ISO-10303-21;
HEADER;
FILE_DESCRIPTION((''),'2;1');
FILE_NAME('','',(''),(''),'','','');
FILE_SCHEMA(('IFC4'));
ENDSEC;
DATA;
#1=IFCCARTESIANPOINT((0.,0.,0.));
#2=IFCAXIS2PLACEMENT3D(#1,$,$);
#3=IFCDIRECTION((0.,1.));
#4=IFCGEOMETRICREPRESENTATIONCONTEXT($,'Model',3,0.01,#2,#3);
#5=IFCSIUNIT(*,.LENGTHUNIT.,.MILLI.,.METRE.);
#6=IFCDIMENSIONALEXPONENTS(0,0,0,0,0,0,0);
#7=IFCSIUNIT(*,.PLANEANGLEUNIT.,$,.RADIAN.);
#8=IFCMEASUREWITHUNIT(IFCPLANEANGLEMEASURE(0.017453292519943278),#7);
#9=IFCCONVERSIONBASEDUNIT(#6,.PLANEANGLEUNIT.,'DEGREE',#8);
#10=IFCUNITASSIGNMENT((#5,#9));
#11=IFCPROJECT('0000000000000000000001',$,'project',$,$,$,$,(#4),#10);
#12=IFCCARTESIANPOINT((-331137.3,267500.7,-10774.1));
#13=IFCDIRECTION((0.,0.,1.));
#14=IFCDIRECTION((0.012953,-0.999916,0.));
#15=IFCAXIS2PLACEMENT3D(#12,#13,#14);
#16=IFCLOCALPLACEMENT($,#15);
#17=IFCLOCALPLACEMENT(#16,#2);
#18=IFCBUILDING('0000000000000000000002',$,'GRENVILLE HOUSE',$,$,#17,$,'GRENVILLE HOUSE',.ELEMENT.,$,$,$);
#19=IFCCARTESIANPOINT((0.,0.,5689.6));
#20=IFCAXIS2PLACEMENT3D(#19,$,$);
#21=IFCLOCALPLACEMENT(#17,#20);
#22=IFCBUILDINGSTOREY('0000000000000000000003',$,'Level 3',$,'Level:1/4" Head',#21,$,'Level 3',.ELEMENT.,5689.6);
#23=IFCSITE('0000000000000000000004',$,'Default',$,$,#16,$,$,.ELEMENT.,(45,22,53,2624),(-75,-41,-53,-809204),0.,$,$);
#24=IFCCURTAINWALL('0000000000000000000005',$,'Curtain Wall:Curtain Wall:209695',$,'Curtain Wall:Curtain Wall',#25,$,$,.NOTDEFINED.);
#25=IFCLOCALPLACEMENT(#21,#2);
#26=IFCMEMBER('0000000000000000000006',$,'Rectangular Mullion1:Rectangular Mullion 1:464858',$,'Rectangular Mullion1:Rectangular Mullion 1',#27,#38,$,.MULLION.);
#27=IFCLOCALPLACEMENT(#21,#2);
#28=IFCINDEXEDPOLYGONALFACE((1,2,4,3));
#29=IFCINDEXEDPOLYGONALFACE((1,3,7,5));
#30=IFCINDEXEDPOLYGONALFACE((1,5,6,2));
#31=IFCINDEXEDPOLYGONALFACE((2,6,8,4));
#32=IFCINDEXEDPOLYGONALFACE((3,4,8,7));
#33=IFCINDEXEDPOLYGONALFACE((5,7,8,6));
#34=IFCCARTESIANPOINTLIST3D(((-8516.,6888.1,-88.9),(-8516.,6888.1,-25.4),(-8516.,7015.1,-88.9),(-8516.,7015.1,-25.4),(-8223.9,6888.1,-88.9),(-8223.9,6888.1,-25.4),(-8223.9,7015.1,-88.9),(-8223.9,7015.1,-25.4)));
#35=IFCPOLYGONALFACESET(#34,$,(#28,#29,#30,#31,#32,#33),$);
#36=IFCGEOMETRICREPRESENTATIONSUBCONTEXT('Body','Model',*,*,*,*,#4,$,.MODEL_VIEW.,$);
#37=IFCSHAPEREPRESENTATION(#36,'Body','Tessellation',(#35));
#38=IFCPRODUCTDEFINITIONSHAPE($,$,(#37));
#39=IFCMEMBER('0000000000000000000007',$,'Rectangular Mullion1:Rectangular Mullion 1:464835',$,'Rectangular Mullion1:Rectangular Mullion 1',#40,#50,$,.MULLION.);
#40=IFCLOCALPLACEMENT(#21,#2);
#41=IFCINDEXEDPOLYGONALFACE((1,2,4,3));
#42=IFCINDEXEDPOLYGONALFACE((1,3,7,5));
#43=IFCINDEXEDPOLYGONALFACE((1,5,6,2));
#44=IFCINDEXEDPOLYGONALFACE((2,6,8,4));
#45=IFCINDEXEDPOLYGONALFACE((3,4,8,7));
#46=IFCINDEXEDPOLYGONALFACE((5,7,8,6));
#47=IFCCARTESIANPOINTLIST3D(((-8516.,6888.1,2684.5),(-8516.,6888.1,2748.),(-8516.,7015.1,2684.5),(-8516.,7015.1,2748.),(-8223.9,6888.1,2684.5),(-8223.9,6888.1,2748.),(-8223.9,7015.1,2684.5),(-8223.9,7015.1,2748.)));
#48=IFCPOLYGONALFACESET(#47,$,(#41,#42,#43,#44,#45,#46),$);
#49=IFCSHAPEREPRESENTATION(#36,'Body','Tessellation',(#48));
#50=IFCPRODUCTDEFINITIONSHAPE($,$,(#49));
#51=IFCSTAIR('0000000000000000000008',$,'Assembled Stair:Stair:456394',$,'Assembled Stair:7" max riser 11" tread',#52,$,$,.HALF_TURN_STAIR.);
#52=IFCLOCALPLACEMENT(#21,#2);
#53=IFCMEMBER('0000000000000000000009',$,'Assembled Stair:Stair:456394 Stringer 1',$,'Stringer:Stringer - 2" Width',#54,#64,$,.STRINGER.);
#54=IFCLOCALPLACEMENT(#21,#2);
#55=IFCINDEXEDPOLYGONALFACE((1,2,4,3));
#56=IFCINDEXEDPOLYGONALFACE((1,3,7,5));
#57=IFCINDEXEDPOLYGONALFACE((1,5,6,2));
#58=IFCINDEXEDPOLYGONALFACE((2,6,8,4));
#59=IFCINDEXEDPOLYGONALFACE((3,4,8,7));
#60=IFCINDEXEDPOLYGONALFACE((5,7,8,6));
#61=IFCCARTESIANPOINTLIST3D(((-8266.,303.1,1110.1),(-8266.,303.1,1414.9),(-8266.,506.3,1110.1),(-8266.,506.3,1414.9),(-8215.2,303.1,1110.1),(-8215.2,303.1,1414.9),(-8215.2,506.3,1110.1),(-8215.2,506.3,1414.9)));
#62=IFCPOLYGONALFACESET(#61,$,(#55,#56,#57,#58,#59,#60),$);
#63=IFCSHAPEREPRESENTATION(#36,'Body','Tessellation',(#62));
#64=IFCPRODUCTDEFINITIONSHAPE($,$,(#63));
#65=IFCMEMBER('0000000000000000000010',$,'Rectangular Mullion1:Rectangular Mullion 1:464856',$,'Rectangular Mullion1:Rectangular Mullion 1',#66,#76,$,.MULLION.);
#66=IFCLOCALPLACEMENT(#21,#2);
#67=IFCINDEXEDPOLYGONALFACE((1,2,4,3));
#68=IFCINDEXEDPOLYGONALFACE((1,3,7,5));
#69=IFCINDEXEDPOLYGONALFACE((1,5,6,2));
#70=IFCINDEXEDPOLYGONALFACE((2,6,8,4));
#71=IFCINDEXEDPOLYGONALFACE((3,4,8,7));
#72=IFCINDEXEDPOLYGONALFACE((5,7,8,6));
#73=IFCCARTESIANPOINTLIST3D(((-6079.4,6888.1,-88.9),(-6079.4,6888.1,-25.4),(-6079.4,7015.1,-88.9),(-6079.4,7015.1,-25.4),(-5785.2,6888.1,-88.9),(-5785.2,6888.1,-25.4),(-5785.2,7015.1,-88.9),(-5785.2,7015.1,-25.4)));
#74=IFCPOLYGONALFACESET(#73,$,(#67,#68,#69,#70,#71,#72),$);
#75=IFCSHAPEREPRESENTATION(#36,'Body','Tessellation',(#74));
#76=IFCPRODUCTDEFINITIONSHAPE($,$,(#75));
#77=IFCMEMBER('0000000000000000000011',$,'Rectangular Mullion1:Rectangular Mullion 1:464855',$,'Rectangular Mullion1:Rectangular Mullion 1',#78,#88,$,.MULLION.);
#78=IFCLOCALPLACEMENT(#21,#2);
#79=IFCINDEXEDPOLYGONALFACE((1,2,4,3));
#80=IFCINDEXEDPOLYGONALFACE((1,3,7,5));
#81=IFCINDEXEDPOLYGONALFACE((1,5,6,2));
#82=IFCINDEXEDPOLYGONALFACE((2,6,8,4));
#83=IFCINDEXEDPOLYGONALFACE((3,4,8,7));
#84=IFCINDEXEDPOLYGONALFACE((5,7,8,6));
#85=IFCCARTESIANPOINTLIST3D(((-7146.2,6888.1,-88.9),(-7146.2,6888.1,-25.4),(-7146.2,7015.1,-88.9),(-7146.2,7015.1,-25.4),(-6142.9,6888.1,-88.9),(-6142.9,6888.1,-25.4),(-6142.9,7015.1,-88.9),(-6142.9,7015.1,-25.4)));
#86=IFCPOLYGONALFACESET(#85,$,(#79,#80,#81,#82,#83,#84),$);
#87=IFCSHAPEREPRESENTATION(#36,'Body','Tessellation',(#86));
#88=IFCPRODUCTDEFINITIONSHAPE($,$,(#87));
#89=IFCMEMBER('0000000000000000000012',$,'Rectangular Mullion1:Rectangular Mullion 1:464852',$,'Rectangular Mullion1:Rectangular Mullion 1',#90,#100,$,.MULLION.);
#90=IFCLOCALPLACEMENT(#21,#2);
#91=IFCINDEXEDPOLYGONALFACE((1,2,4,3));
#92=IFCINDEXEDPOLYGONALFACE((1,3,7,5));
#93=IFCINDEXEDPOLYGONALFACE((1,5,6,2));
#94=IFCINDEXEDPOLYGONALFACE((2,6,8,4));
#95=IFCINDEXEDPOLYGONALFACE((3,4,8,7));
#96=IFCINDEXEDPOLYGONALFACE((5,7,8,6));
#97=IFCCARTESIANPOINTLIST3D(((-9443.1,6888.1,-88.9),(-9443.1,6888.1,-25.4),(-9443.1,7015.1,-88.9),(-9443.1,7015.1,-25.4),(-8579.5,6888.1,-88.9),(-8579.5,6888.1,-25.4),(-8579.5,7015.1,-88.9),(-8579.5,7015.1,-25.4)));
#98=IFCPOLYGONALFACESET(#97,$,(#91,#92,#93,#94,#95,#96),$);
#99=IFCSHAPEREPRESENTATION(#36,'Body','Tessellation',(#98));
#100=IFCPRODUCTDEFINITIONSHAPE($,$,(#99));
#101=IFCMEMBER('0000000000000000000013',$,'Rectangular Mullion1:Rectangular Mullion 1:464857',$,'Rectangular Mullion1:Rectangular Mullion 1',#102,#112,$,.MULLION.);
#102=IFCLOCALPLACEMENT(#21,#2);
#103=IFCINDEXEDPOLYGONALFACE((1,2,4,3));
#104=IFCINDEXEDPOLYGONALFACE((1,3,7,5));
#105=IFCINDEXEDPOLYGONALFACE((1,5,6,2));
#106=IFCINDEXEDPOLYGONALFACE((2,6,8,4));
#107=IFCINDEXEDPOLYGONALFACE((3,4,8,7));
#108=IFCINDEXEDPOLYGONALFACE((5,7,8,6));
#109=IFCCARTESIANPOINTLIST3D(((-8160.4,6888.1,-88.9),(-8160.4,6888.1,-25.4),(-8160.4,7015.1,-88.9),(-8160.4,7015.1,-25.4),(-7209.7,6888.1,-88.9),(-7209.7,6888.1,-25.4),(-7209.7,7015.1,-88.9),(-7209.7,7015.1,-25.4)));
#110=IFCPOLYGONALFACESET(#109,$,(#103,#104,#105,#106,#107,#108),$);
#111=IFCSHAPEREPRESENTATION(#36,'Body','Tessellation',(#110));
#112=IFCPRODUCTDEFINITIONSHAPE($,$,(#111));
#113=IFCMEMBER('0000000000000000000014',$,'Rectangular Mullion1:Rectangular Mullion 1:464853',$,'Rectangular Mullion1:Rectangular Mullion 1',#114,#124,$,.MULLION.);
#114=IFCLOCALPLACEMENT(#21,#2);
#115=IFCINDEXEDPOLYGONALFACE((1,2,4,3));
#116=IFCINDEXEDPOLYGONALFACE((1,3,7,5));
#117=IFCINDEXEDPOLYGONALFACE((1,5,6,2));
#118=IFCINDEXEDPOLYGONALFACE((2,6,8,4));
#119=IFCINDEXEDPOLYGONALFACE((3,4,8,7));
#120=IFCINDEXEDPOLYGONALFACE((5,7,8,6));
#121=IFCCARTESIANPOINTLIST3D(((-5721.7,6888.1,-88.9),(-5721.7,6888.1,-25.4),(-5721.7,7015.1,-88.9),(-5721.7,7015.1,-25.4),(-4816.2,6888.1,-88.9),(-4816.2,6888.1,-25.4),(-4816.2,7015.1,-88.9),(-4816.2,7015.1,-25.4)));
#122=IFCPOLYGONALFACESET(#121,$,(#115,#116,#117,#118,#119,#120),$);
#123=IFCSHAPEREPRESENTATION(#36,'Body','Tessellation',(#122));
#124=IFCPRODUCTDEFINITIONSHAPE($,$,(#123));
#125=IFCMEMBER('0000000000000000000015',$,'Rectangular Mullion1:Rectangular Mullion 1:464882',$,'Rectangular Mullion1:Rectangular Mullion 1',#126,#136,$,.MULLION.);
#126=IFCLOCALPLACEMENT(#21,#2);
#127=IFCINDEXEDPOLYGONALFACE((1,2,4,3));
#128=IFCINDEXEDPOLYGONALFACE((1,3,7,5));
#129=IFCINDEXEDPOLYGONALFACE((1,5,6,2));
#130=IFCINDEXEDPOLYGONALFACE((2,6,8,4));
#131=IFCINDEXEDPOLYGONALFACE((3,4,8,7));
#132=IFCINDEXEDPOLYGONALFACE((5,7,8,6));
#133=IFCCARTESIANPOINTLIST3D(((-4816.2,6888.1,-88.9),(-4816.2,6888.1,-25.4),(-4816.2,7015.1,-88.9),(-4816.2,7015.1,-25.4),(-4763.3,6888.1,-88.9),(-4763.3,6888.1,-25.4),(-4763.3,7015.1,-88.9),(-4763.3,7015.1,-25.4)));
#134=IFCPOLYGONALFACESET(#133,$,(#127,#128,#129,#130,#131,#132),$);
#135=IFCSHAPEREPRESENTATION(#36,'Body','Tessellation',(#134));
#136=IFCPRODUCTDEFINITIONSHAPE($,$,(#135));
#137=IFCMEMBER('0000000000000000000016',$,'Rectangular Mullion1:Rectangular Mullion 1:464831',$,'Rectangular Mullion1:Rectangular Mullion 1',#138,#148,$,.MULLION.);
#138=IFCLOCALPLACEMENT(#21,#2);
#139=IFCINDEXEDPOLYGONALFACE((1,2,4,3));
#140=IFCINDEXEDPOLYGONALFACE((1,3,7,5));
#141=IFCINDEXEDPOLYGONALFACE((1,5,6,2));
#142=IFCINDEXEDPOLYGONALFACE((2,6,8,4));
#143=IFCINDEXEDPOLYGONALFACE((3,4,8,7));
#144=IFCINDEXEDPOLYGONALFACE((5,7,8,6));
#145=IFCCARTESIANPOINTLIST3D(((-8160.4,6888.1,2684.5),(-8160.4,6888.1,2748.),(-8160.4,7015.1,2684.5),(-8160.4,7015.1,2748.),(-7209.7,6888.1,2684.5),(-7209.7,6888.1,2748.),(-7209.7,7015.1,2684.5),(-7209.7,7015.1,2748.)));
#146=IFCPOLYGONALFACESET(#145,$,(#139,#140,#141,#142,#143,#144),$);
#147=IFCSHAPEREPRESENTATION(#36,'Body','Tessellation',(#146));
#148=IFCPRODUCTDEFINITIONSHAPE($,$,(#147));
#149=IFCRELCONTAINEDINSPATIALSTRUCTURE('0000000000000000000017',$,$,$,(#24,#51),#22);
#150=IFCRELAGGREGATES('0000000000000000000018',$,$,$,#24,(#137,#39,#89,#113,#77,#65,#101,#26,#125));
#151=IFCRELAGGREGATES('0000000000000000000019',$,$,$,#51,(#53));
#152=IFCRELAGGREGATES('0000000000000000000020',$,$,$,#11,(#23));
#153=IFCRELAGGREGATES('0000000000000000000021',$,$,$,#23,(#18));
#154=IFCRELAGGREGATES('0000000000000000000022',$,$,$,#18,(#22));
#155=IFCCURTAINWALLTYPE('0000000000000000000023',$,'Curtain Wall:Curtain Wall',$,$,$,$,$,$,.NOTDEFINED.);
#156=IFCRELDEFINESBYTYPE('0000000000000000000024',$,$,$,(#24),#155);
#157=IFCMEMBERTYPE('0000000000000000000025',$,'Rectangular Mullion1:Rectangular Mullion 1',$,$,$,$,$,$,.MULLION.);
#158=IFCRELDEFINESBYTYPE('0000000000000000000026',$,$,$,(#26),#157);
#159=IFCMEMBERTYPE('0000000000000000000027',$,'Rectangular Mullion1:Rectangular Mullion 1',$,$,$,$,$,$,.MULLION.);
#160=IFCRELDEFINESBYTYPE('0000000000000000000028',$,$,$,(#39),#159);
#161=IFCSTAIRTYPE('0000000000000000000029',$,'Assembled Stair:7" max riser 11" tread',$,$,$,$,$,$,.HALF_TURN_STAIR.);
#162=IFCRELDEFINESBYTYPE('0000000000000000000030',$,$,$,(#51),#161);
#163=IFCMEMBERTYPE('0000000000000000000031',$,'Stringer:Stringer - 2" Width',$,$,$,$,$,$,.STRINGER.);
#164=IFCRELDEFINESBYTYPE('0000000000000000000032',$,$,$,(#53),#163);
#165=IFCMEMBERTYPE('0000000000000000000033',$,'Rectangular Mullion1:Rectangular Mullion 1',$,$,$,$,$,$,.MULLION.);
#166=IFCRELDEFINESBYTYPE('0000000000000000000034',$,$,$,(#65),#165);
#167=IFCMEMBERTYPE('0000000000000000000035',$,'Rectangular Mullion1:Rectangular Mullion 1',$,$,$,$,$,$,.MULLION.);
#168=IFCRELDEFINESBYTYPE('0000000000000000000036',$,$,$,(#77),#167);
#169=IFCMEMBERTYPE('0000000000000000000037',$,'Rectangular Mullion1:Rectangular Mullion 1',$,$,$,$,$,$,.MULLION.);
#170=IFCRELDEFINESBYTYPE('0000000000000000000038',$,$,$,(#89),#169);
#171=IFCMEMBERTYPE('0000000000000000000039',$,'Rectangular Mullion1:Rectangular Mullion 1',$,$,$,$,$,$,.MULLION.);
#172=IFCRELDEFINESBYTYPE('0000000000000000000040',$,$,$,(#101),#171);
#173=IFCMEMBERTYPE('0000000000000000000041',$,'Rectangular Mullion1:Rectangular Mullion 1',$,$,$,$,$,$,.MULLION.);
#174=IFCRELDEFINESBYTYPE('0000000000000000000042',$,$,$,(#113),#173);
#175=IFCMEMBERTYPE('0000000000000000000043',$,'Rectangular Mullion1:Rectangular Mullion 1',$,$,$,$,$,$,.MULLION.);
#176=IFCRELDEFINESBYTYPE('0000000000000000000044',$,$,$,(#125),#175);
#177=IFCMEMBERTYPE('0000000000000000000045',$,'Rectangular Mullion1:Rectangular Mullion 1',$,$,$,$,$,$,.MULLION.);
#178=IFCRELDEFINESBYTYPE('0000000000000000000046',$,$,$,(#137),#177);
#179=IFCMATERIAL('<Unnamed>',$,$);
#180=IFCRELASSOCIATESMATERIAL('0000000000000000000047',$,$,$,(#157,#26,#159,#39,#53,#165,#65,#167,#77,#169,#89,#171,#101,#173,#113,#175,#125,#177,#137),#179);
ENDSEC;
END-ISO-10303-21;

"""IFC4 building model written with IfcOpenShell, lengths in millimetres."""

from ifc_helpers import new_model, entity, si_unit, converted_unit, direction, frame, origin, place, context, subcontext, project, spatial, indexed_curve, outline, extrude, source, transform, mapped, material, type_object, type_shapes, element, aggregate, save


model = new_model("IFC4")

# Units and contexts
model_context = context("Model", 3, precision=0.01, world=origin(), true_north=direction((0.0, 1.0)))
body_context = subcontext(model_context, "Body", "Model", "MODEL_VIEW")
ifc_project = project(units=[si_unit("LENGTHUNIT", "METRE", prefix="MILLI"), converted_unit("PLANEANGLEUNIT", "DEGREE", entity("IfcPlaneAngleMeasure", 0.017453292519943278), si_unit("PLANEANGLEUNIT", "RADIAN"), dimensions=[0, 0, 0, 0, 0, 0, 0])], contexts=[model_context])

# Site, building, storey
site_placement = place(None, frame((-331137.3, 267500.7, -10774.1), z_axis=(0.0, 0.0, 1.0), x_axis=(0.012953, -0.999916, 0.0)))
site = spatial("IfcSite", under=ifc_project, at=site_placement, Name="Default", CompositionType="ELEMENT", RefLatitude=(45, 22, 53, 2624), RefLongitude=(-75, -41, -53, -809204), RefElevation=0.0)
building_placement = place(site_placement, origin())
building = spatial("IfcBuilding", under=site, at=building_placement, Name="GRENVILLE HOUSE", LongName="GRENVILLE HOUSE", CompositionType="ELEMENT")
storey_placement = place(building_placement, frame((0.0, 0.0, 5689.6)))
storey = spatial("IfcBuildingStorey", under=building, at=storey_placement, Name="Level 3", ObjectType="Level:1/4\" Head", LongName="Level 3", CompositionType="ELEMENT", Elevation=5689.6)

# Curtain wall, members
curtain_wall_type = type_object("IfcCurtainWallType", Name="Curtain Wall:Curtain Wall", PredefinedType="NOTDEFINED")
curtain_wall_placement = place(storey_placement, frame((0.0, 0.0, -5689.6)))
curtain_wall = element("IfcCurtainWall", 1, at=curtain_wall_placement, inside=storey, type_object=curtain_wall_type, Name="Curtain Wall:Curtain Wall:209695", ObjectType="Curtain Wall:Curtain Wall", PredefinedType="NOTDEFINED")
ifc_material_1 = material(Name="<Unnamed>")
member_type_1 = type_object("IfcMemberType", Name="Rectangular Mullion1:Rectangular Mullion 1", PredefinedType="MULLION", material=ifc_material_1)
shared_shape_1 = source(origin(), body_context, "Body", "SweptSolid", [
    extrude(outline(indexed_curve([(-31.8, -63.5), (31.8, -63.5), (31.8, 63.5), (-31.8, 63.5), (-31.8, -63.5)], self_intersect=False)), frame((-31.8, 0.0, -292.1), z_axis=(0.0, 0.0, 1.0), x_axis=(-1.0, 0.0, 0.0)), (0.0, 0.0, 1.0), 292.1),
])
type_shapes(member_type_1, [shared_shape_1])
member_1_placement = place(curtain_wall_placement, frame((-8223.9, 6951.6, 5600.7), z_axis=(1.0, 0.0, 0.0), x_axis=(0.0, 0.0, -1.0)))
member_1 = element("IfcMember", 2, at=member_1_placement, type_object=member_type_1, material=ifc_material_1, Name="Rectangular Mullion1:Rectangular Mullion 1:464858", ObjectType="Rectangular Mullion1:Rectangular Mullion 1", PredefinedType="MULLION", context=body_context, shape_type="MappedRepresentation", body=[
    mapped(shared_shape_1, transform((0.0, 0.0, 0.0), scale=1.0)),
])
member_type_2 = type_object("IfcMemberType", Name="Rectangular Mullion1:Rectangular Mullion 1", PredefinedType="MULLION", material=ifc_material_1)
shared_shape_2 = source(origin(), body_context, "Body", "SweptSolid", [
    extrude(outline(indexed_curve([(-31.8, -63.5), (31.8, -63.5), (31.8, 63.5), (-31.8, 63.5), (-31.8, -63.5)], self_intersect=False)), frame((-31.8, 0.0, -292.1), z_axis=(0.0, 0.0, 1.0), x_axis=(-1.0, 0.0, 0.0)), (0.0, 0.0, 1.0), 292.1),
])
type_shapes(member_type_2, [shared_shape_2])
member_2_placement = place(curtain_wall_placement, frame((-8516.0, 6951.6, 8437.6), z_axis=(-1.0, 0.0, 0.0), x_axis=(0.0, 0.0, 1.0)))
member_2 = element("IfcMember", 3, at=member_2_placement, type_object=member_type_2, material=ifc_material_1, Name="Rectangular Mullion1:Rectangular Mullion 1:464835", ObjectType="Rectangular Mullion1:Rectangular Mullion 1", PredefinedType="MULLION", context=body_context, shape_type="MappedRepresentation", body=[
    mapped(shared_shape_2, transform((0.0, 0.0, 0.0), scale=1.0)),
])

# Stair, member
stair_type = type_object("IfcStairType", Name="Assembled Stair:7\" max riser 11\" tread", PredefinedType="HALF_TURN_STAIR")
stair_placement = place(storey_placement, origin())
stair = element("IfcStair", 4, at=stair_placement, inside=storey, type_object=stair_type, Name="Assembled Stair:Stair:456394", ObjectType="Assembled Stair:7\" max riser 11\" tread", PredefinedType="HALF_TURN_STAIR")
member_type_3 = type_object("IfcMemberType", Name="Stringer:Stringer - 2\" Width", PredefinedType="STRINGER")
member_3_placement = place(stair_placement, frame((-8266.0, 303.1, 1110.1)))
member_3 = element("IfcMember", 5, at=member_3_placement, type_object=member_type_3, material=ifc_material_1, Name="Assembled Stair:Stair:456394 Stringer 1", ObjectType="Stringer:Stringer - 2\" Width", PredefinedType="STRINGER", context=body_context, shape_type="SweptSolid", body=[
    extrude(outline(indexed_curve([(-101.6, -25.4), (101.6, -25.4), (101.6, 25.4), (-101.6, 25.4), (-101.6, -25.4)], self_intersect=False)), frame((25.4, 101.6, 0.0), z_axis=(0.0, 0.0, 1.0), x_axis=(0.0, 1.0, 0.0)), (0.0, 0.0, 1.0), 304.8),
])

# Members
member_type_4 = type_object("IfcMemberType", Name="Rectangular Mullion1:Rectangular Mullion 1", PredefinedType="MULLION", material=ifc_material_1)
shared_shape_3 = source(origin(), body_context, "Body", "SweptSolid", [
    extrude(outline(indexed_curve([(-31.8, -63.5), (31.8, -63.5), (31.8, 63.5), (-31.8, 63.5), (-31.8, -63.5)], self_intersect=False)), frame((-31.8, 0.0, -294.2), z_axis=(0.0, 0.0, 1.0), x_axis=(-1.0, 0.0, 0.0)), (0.0, 0.0, 1.0), 294.2),
])
type_shapes(member_type_4, [shared_shape_3])
member_4_placement = place(curtain_wall_placement, frame((-5785.2, 6951.6, 5600.7), z_axis=(1.0, 0.0, 0.0), x_axis=(0.0, 0.0, -1.0)))
member_4 = element("IfcMember", 6, at=member_4_placement, type_object=member_type_4, material=ifc_material_1, Name="Rectangular Mullion1:Rectangular Mullion 1:464856", ObjectType="Rectangular Mullion1:Rectangular Mullion 1", PredefinedType="MULLION", context=body_context, shape_type="MappedRepresentation", body=[
    mapped(shared_shape_3, transform((0.0, 0.0, 0.0), scale=1.0)),
])
member_type_5 = type_object("IfcMemberType", Name="Rectangular Mullion1:Rectangular Mullion 1", PredefinedType="MULLION", material=ifc_material_1)
shared_shape_4 = source(origin(), body_context, "Body", "SweptSolid", [
    extrude(outline(indexed_curve([(-31.8, -63.5), (31.8, -63.5), (31.8, 63.5), (-31.8, 63.5), (-31.8, -63.5)], self_intersect=False)), frame((-31.8, 0.0, -1003.3), z_axis=(0.0, 0.0, 1.0), x_axis=(-1.0, 0.0, 0.0)), (0.0, 0.0, 1.0), 1003.3),
])
type_shapes(member_type_5, [shared_shape_4])
member_5_placement = place(curtain_wall_placement, frame((-6142.9, 6951.6, 5600.7), z_axis=(1.0, 0.0, 0.0), x_axis=(0.0, 0.0, -1.0)))
member_5 = element("IfcMember", 7, at=member_5_placement, type_object=member_type_5, material=ifc_material_1, Name="Rectangular Mullion1:Rectangular Mullion 1:464855", ObjectType="Rectangular Mullion1:Rectangular Mullion 1", PredefinedType="MULLION", context=body_context, shape_type="MappedRepresentation", body=[
    mapped(shared_shape_4, transform((0.0, 0.0, 0.0), scale=1.0)),
])
member_type_6 = type_object("IfcMemberType", Name="Rectangular Mullion1:Rectangular Mullion 1", PredefinedType="MULLION", material=ifc_material_1)
shared_shape_5 = source(origin(), body_context, "Body", "SweptSolid", [
    extrude(outline(indexed_curve([(-31.8, -63.5), (31.8, -63.5), (31.8, 63.5), (-31.8, 63.5), (-31.8, -63.5)], self_intersect=False)), frame((-31.8, 0.0, -863.6), z_axis=(0.0, 0.0, 1.0), x_axis=(-1.0, 0.0, 0.0)), (0.0, 0.0, 1.0), 863.6),
])
type_shapes(member_type_6, [shared_shape_5])
member_6_placement = place(curtain_wall_placement, frame((-8579.5, 6951.6, 5600.7), z_axis=(1.0, 0.0, 0.0), x_axis=(0.0, 0.0, -1.0)))
member_6 = element("IfcMember", 8, at=member_6_placement, type_object=member_type_6, material=ifc_material_1, Name="Rectangular Mullion1:Rectangular Mullion 1:464852", ObjectType="Rectangular Mullion1:Rectangular Mullion 1", PredefinedType="MULLION", context=body_context, shape_type="MappedRepresentation", body=[
    mapped(shared_shape_5, transform((0.0, 0.0, 0.0), scale=1.0)),
])
member_type_7 = type_object("IfcMemberType", Name="Rectangular Mullion1:Rectangular Mullion 1", PredefinedType="MULLION", material=ifc_material_1)
shared_shape_6 = source(origin(), body_context, "Body", "SweptSolid", [
    extrude(outline(indexed_curve([(-31.8, -63.5), (31.8, -63.5), (31.8, 63.5), (-31.8, 63.5), (-31.8, -63.5)], self_intersect=False)), frame((-31.8, 0.0, -950.7), z_axis=(0.0, 0.0, 1.0), x_axis=(-1.0, 0.0, 0.0)), (0.0, 0.0, 1.0), 950.7),
])
type_shapes(member_type_7, [shared_shape_6])
member_7_placement = place(curtain_wall_placement, frame((-7209.7, 6951.6, 5600.7), z_axis=(1.0, 0.0, 0.0), x_axis=(0.0, 0.0, -1.0)))
member_7 = element("IfcMember", 9, at=member_7_placement, type_object=member_type_7, material=ifc_material_1, Name="Rectangular Mullion1:Rectangular Mullion 1:464857", ObjectType="Rectangular Mullion1:Rectangular Mullion 1", PredefinedType="MULLION", context=body_context, shape_type="MappedRepresentation", body=[
    mapped(shared_shape_6, transform((0.0, 0.0, 0.0), scale=1.0)),
])
member_type_8 = type_object("IfcMemberType", Name="Rectangular Mullion1:Rectangular Mullion 1", PredefinedType="MULLION", material=ifc_material_1)
shared_shape_7 = source(origin(), body_context, "Body", "SweptSolid", [
    extrude(outline(indexed_curve([(-31.8, -63.5), (31.8, -63.5), (31.8, 63.5), (-31.8, 63.5), (-31.8, -63.5)], self_intersect=False)), frame((-31.8, 0.0, -905.5), z_axis=(0.0, 0.0, 1.0), x_axis=(-1.0, 0.0, 0.0)), (0.0, 0.0, 1.0), 905.5),
])
type_shapes(member_type_8, [shared_shape_7])
member_8_placement = place(curtain_wall_placement, frame((-4816.2, 6951.6, 5600.7), z_axis=(1.0, 0.0, 0.0), x_axis=(0.0, 0.0, -1.0)))
member_8 = element("IfcMember", 10, at=member_8_placement, type_object=member_type_8, material=ifc_material_1, Name="Rectangular Mullion1:Rectangular Mullion 1:464853", ObjectType="Rectangular Mullion1:Rectangular Mullion 1", PredefinedType="MULLION", context=body_context, shape_type="MappedRepresentation", body=[
    mapped(shared_shape_7, transform((0.0, 0.0, 0.0), scale=1.0)),
])
member_type_9 = type_object("IfcMemberType", Name="Rectangular Mullion1:Rectangular Mullion 1", PredefinedType="MULLION", material=ifc_material_1)
shared_shape_8 = source(origin(), body_context, "Body", "SweptSolid", [
    extrude(outline(indexed_curve([(-31.8, -63.5), (31.8, -63.5), (31.8, 63.5), (-31.8, 63.5), (-31.8, -63.5)], self_intersect=False)), frame((-31.8, 0.0, -52.9), z_axis=(0.0, 0.0, 1.0), x_axis=(-1.0, 0.0, 0.0)), (0.0, 0.0, 1.0), 52.9),
])
type_shapes(member_type_9, [shared_shape_8])
member_9_placement = place(curtain_wall_placement, frame((-4763.3, 6951.6, 5600.7), z_axis=(1.0, 0.0, 0.0), x_axis=(0.0, 0.0, -1.0)))
member_9 = element("IfcMember", 11, at=member_9_placement, type_object=member_type_9, material=ifc_material_1, Name="Rectangular Mullion1:Rectangular Mullion 1:464882", ObjectType="Rectangular Mullion1:Rectangular Mullion 1", PredefinedType="MULLION", context=body_context, shape_type="MappedRepresentation", body=[
    mapped(shared_shape_8, transform((0.0, 0.0, 0.0), scale=1.0)),
])
member_type_10 = type_object("IfcMemberType", Name="Rectangular Mullion1:Rectangular Mullion 1", PredefinedType="MULLION", material=ifc_material_1)
shared_shape_9 = source(origin(), body_context, "Body", "SweptSolid", [
    extrude(outline(indexed_curve([(-31.8, -63.5), (31.8, -63.5), (31.8, 63.5), (-31.8, 63.5), (-31.8, -63.5)], self_intersect=False)), frame((-31.8, 0.0, -950.7), z_axis=(0.0, 0.0, 1.0), x_axis=(-1.0, 0.0, 0.0)), (0.0, 0.0, 1.0), 950.7),
])
type_shapes(member_type_10, [shared_shape_9])
member_10_placement = place(curtain_wall_placement, frame((-8160.4, 6951.6, 8437.6), z_axis=(-1.0, 0.0, 0.0), x_axis=(0.0, 0.0, 1.0)))
member_10 = element("IfcMember", 12, at=member_10_placement, type_object=member_type_10, material=ifc_material_1, Name="Rectangular Mullion1:Rectangular Mullion 1:464831", ObjectType="Rectangular Mullion1:Rectangular Mullion 1", PredefinedType="MULLION", context=body_context, shape_type="MappedRepresentation", body=[
    mapped(shared_shape_9, transform((0.0, 0.0, 0.0), scale=1.0)),
])

aggregate(curtain_wall, [member_10, member_2, member_6, member_8, member_5, member_4, member_7, member_1, member_9])

aggregate(stair, [member_3])

save(model, "model.ifc")
